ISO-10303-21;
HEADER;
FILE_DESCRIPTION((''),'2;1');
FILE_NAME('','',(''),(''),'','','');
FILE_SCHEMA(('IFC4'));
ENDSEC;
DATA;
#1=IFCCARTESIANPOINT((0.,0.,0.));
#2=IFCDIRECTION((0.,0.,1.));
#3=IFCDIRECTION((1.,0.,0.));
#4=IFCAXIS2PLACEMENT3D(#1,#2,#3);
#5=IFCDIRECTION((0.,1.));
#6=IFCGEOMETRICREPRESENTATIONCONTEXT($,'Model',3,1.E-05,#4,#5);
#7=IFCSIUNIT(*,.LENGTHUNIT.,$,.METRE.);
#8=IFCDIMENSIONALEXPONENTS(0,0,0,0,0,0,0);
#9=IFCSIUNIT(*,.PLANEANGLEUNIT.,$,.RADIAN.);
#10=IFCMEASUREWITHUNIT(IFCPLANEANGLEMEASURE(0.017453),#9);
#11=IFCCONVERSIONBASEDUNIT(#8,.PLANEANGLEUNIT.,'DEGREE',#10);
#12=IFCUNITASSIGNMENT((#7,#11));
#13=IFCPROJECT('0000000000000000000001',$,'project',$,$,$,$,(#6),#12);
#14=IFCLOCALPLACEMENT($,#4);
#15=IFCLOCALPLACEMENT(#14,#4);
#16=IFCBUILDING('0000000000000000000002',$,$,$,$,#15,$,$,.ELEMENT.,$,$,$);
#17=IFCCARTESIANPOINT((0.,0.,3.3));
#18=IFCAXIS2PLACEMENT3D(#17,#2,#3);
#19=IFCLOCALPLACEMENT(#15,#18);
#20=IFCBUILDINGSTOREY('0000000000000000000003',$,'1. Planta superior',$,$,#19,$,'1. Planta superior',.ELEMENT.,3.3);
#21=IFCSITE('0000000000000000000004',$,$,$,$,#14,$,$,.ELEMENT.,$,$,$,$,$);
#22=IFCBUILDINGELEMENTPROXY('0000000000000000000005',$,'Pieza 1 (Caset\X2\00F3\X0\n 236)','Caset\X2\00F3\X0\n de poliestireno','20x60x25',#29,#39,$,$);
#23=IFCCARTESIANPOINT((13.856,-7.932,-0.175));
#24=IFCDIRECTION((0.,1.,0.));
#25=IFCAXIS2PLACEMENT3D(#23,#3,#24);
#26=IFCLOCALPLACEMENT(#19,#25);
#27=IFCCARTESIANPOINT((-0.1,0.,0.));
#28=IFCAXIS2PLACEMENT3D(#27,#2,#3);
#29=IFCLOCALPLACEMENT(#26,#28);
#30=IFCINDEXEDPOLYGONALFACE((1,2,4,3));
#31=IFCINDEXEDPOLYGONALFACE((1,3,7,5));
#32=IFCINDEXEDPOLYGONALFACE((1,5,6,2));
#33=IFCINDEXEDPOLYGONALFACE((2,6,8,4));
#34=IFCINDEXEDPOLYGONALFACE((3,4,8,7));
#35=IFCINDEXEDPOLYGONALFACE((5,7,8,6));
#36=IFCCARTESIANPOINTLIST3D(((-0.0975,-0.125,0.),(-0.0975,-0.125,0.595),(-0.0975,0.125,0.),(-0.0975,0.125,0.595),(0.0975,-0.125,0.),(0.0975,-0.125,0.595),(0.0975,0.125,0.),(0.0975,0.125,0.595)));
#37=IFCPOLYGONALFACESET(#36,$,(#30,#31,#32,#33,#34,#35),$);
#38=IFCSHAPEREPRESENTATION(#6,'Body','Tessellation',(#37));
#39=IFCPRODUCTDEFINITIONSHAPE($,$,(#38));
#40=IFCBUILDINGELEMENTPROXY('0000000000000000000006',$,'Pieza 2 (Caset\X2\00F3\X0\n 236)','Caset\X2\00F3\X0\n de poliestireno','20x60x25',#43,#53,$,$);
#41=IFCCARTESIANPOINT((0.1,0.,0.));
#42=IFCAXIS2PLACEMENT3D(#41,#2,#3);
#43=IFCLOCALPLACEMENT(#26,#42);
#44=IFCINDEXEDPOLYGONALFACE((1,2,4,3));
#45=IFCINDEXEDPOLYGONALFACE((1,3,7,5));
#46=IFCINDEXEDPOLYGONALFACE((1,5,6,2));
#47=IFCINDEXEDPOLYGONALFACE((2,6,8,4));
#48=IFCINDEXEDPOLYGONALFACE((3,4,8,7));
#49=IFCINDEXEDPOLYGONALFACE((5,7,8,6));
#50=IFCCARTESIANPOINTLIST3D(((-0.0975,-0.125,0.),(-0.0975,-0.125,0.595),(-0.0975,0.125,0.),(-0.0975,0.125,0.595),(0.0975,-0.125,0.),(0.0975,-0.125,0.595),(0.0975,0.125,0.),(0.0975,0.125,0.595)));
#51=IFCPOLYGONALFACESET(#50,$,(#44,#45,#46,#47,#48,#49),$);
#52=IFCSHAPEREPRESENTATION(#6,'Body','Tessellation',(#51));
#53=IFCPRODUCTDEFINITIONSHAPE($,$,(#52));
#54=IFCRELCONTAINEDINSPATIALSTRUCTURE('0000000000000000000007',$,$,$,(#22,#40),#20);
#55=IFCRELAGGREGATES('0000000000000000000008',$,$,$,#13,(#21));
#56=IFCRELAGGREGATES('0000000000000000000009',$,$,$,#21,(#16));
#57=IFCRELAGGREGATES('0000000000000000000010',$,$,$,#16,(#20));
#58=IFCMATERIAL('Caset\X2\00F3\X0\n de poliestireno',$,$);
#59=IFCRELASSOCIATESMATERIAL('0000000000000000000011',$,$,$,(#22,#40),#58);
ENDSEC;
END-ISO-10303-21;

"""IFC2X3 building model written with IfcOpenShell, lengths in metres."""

from ifc_helpers import new_model, entity, si_unit, converted_unit, direction, frame, origin_with_axes, origin_2d_with_axis, place, context, project, spatial, rectangle, extrude, source, transform, mapped, material, element, save


model = new_model("IFC2X3")

# Units and contexts
model_context = context("Model", 3, precision=1e-05, world=origin_with_axes(), true_north=direction((0.0, 1.0)))
ifc_project = project(units=[si_unit("LENGTHUNIT", "METRE"), converted_unit("PLANEANGLEUNIT", "DEGREE", entity("IfcPlaneAngleMeasure", 0.017453), si_unit("PLANEANGLEUNIT", "RADIAN"), dimensions=[0, 0, 0, 0, 0, 0, 0])], contexts=[model_context])

# Site, building, storey
site_placement = place(None, origin_with_axes())
site = spatial("IfcSite", under=ifc_project, at=site_placement, CompositionType="ELEMENT")
building_placement = place(site_placement, origin_with_axes())
building = spatial("IfcBuilding", under=site, at=building_placement, CompositionType="ELEMENT")
storey_placement = place(building_placement, frame((0.0, 0.0, 3.3), z_axis=(0.0, 0.0, 1.0), x_axis=(1.0, 0.0, 0.0)))
storey = spatial("IfcBuildingStorey", under=building, at=storey_placement, Name="1. Planta superior", LongName="1. Planta superior", CompositionType="ELEMENT", Elevation=3.3)

# Building element proxies
ifc_material_1 = material(Name="Casetón de poliestireno")
shared_shape = source(origin_with_axes(), model_context, "Body", "SweptSolid", [
    extrude(rectangle(XDim=0.195, YDim=0.25, at=origin_2d_with_axis()), origin_with_axes(), (0.0, 0.0, 1.0), 0.595),
])
placement_1 = place(storey_placement, frame((13.856, -7.932, -0.175), z_axis=(1.0, 0.0, 0.0), x_axis=(0.0, 1.0, 0.0)))
for number, where, z_axis, x_axis, name in (
    (1, (-0.1, 0.0, 0.0), (0.0, 0.0, 1.0), (1.0, 0.0, 0.0), "Pieza 1 (Casetón 236)"),
    (2, (0.1, 0.0, 0.0), (0.0, 0.0, 1.0), (1.0, 0.0, 0.0), "Pieza 2 (Casetón 236)"),
):
    element("IfcBuildingElementProxy", number, at=place(placement_1, frame(where, z_axis=z_axis, x_axis=x_axis)), inside=storey, material=ifc_material_1, Name=name, Description="Casetón de poliestireno", ObjectType="20x60x25", context=model_context, shape_type="MappedRepresentation", body=[
        mapped(shared_shape, transform((0.0, 0.0, 0.0), x_axis=(1.0, 0.0, 0.0), y_axis=(0.0, 1.0, 0.0), z_axis=(0.0, 0.0, 1.0))),
    ])

save(model, "model.ifc")
